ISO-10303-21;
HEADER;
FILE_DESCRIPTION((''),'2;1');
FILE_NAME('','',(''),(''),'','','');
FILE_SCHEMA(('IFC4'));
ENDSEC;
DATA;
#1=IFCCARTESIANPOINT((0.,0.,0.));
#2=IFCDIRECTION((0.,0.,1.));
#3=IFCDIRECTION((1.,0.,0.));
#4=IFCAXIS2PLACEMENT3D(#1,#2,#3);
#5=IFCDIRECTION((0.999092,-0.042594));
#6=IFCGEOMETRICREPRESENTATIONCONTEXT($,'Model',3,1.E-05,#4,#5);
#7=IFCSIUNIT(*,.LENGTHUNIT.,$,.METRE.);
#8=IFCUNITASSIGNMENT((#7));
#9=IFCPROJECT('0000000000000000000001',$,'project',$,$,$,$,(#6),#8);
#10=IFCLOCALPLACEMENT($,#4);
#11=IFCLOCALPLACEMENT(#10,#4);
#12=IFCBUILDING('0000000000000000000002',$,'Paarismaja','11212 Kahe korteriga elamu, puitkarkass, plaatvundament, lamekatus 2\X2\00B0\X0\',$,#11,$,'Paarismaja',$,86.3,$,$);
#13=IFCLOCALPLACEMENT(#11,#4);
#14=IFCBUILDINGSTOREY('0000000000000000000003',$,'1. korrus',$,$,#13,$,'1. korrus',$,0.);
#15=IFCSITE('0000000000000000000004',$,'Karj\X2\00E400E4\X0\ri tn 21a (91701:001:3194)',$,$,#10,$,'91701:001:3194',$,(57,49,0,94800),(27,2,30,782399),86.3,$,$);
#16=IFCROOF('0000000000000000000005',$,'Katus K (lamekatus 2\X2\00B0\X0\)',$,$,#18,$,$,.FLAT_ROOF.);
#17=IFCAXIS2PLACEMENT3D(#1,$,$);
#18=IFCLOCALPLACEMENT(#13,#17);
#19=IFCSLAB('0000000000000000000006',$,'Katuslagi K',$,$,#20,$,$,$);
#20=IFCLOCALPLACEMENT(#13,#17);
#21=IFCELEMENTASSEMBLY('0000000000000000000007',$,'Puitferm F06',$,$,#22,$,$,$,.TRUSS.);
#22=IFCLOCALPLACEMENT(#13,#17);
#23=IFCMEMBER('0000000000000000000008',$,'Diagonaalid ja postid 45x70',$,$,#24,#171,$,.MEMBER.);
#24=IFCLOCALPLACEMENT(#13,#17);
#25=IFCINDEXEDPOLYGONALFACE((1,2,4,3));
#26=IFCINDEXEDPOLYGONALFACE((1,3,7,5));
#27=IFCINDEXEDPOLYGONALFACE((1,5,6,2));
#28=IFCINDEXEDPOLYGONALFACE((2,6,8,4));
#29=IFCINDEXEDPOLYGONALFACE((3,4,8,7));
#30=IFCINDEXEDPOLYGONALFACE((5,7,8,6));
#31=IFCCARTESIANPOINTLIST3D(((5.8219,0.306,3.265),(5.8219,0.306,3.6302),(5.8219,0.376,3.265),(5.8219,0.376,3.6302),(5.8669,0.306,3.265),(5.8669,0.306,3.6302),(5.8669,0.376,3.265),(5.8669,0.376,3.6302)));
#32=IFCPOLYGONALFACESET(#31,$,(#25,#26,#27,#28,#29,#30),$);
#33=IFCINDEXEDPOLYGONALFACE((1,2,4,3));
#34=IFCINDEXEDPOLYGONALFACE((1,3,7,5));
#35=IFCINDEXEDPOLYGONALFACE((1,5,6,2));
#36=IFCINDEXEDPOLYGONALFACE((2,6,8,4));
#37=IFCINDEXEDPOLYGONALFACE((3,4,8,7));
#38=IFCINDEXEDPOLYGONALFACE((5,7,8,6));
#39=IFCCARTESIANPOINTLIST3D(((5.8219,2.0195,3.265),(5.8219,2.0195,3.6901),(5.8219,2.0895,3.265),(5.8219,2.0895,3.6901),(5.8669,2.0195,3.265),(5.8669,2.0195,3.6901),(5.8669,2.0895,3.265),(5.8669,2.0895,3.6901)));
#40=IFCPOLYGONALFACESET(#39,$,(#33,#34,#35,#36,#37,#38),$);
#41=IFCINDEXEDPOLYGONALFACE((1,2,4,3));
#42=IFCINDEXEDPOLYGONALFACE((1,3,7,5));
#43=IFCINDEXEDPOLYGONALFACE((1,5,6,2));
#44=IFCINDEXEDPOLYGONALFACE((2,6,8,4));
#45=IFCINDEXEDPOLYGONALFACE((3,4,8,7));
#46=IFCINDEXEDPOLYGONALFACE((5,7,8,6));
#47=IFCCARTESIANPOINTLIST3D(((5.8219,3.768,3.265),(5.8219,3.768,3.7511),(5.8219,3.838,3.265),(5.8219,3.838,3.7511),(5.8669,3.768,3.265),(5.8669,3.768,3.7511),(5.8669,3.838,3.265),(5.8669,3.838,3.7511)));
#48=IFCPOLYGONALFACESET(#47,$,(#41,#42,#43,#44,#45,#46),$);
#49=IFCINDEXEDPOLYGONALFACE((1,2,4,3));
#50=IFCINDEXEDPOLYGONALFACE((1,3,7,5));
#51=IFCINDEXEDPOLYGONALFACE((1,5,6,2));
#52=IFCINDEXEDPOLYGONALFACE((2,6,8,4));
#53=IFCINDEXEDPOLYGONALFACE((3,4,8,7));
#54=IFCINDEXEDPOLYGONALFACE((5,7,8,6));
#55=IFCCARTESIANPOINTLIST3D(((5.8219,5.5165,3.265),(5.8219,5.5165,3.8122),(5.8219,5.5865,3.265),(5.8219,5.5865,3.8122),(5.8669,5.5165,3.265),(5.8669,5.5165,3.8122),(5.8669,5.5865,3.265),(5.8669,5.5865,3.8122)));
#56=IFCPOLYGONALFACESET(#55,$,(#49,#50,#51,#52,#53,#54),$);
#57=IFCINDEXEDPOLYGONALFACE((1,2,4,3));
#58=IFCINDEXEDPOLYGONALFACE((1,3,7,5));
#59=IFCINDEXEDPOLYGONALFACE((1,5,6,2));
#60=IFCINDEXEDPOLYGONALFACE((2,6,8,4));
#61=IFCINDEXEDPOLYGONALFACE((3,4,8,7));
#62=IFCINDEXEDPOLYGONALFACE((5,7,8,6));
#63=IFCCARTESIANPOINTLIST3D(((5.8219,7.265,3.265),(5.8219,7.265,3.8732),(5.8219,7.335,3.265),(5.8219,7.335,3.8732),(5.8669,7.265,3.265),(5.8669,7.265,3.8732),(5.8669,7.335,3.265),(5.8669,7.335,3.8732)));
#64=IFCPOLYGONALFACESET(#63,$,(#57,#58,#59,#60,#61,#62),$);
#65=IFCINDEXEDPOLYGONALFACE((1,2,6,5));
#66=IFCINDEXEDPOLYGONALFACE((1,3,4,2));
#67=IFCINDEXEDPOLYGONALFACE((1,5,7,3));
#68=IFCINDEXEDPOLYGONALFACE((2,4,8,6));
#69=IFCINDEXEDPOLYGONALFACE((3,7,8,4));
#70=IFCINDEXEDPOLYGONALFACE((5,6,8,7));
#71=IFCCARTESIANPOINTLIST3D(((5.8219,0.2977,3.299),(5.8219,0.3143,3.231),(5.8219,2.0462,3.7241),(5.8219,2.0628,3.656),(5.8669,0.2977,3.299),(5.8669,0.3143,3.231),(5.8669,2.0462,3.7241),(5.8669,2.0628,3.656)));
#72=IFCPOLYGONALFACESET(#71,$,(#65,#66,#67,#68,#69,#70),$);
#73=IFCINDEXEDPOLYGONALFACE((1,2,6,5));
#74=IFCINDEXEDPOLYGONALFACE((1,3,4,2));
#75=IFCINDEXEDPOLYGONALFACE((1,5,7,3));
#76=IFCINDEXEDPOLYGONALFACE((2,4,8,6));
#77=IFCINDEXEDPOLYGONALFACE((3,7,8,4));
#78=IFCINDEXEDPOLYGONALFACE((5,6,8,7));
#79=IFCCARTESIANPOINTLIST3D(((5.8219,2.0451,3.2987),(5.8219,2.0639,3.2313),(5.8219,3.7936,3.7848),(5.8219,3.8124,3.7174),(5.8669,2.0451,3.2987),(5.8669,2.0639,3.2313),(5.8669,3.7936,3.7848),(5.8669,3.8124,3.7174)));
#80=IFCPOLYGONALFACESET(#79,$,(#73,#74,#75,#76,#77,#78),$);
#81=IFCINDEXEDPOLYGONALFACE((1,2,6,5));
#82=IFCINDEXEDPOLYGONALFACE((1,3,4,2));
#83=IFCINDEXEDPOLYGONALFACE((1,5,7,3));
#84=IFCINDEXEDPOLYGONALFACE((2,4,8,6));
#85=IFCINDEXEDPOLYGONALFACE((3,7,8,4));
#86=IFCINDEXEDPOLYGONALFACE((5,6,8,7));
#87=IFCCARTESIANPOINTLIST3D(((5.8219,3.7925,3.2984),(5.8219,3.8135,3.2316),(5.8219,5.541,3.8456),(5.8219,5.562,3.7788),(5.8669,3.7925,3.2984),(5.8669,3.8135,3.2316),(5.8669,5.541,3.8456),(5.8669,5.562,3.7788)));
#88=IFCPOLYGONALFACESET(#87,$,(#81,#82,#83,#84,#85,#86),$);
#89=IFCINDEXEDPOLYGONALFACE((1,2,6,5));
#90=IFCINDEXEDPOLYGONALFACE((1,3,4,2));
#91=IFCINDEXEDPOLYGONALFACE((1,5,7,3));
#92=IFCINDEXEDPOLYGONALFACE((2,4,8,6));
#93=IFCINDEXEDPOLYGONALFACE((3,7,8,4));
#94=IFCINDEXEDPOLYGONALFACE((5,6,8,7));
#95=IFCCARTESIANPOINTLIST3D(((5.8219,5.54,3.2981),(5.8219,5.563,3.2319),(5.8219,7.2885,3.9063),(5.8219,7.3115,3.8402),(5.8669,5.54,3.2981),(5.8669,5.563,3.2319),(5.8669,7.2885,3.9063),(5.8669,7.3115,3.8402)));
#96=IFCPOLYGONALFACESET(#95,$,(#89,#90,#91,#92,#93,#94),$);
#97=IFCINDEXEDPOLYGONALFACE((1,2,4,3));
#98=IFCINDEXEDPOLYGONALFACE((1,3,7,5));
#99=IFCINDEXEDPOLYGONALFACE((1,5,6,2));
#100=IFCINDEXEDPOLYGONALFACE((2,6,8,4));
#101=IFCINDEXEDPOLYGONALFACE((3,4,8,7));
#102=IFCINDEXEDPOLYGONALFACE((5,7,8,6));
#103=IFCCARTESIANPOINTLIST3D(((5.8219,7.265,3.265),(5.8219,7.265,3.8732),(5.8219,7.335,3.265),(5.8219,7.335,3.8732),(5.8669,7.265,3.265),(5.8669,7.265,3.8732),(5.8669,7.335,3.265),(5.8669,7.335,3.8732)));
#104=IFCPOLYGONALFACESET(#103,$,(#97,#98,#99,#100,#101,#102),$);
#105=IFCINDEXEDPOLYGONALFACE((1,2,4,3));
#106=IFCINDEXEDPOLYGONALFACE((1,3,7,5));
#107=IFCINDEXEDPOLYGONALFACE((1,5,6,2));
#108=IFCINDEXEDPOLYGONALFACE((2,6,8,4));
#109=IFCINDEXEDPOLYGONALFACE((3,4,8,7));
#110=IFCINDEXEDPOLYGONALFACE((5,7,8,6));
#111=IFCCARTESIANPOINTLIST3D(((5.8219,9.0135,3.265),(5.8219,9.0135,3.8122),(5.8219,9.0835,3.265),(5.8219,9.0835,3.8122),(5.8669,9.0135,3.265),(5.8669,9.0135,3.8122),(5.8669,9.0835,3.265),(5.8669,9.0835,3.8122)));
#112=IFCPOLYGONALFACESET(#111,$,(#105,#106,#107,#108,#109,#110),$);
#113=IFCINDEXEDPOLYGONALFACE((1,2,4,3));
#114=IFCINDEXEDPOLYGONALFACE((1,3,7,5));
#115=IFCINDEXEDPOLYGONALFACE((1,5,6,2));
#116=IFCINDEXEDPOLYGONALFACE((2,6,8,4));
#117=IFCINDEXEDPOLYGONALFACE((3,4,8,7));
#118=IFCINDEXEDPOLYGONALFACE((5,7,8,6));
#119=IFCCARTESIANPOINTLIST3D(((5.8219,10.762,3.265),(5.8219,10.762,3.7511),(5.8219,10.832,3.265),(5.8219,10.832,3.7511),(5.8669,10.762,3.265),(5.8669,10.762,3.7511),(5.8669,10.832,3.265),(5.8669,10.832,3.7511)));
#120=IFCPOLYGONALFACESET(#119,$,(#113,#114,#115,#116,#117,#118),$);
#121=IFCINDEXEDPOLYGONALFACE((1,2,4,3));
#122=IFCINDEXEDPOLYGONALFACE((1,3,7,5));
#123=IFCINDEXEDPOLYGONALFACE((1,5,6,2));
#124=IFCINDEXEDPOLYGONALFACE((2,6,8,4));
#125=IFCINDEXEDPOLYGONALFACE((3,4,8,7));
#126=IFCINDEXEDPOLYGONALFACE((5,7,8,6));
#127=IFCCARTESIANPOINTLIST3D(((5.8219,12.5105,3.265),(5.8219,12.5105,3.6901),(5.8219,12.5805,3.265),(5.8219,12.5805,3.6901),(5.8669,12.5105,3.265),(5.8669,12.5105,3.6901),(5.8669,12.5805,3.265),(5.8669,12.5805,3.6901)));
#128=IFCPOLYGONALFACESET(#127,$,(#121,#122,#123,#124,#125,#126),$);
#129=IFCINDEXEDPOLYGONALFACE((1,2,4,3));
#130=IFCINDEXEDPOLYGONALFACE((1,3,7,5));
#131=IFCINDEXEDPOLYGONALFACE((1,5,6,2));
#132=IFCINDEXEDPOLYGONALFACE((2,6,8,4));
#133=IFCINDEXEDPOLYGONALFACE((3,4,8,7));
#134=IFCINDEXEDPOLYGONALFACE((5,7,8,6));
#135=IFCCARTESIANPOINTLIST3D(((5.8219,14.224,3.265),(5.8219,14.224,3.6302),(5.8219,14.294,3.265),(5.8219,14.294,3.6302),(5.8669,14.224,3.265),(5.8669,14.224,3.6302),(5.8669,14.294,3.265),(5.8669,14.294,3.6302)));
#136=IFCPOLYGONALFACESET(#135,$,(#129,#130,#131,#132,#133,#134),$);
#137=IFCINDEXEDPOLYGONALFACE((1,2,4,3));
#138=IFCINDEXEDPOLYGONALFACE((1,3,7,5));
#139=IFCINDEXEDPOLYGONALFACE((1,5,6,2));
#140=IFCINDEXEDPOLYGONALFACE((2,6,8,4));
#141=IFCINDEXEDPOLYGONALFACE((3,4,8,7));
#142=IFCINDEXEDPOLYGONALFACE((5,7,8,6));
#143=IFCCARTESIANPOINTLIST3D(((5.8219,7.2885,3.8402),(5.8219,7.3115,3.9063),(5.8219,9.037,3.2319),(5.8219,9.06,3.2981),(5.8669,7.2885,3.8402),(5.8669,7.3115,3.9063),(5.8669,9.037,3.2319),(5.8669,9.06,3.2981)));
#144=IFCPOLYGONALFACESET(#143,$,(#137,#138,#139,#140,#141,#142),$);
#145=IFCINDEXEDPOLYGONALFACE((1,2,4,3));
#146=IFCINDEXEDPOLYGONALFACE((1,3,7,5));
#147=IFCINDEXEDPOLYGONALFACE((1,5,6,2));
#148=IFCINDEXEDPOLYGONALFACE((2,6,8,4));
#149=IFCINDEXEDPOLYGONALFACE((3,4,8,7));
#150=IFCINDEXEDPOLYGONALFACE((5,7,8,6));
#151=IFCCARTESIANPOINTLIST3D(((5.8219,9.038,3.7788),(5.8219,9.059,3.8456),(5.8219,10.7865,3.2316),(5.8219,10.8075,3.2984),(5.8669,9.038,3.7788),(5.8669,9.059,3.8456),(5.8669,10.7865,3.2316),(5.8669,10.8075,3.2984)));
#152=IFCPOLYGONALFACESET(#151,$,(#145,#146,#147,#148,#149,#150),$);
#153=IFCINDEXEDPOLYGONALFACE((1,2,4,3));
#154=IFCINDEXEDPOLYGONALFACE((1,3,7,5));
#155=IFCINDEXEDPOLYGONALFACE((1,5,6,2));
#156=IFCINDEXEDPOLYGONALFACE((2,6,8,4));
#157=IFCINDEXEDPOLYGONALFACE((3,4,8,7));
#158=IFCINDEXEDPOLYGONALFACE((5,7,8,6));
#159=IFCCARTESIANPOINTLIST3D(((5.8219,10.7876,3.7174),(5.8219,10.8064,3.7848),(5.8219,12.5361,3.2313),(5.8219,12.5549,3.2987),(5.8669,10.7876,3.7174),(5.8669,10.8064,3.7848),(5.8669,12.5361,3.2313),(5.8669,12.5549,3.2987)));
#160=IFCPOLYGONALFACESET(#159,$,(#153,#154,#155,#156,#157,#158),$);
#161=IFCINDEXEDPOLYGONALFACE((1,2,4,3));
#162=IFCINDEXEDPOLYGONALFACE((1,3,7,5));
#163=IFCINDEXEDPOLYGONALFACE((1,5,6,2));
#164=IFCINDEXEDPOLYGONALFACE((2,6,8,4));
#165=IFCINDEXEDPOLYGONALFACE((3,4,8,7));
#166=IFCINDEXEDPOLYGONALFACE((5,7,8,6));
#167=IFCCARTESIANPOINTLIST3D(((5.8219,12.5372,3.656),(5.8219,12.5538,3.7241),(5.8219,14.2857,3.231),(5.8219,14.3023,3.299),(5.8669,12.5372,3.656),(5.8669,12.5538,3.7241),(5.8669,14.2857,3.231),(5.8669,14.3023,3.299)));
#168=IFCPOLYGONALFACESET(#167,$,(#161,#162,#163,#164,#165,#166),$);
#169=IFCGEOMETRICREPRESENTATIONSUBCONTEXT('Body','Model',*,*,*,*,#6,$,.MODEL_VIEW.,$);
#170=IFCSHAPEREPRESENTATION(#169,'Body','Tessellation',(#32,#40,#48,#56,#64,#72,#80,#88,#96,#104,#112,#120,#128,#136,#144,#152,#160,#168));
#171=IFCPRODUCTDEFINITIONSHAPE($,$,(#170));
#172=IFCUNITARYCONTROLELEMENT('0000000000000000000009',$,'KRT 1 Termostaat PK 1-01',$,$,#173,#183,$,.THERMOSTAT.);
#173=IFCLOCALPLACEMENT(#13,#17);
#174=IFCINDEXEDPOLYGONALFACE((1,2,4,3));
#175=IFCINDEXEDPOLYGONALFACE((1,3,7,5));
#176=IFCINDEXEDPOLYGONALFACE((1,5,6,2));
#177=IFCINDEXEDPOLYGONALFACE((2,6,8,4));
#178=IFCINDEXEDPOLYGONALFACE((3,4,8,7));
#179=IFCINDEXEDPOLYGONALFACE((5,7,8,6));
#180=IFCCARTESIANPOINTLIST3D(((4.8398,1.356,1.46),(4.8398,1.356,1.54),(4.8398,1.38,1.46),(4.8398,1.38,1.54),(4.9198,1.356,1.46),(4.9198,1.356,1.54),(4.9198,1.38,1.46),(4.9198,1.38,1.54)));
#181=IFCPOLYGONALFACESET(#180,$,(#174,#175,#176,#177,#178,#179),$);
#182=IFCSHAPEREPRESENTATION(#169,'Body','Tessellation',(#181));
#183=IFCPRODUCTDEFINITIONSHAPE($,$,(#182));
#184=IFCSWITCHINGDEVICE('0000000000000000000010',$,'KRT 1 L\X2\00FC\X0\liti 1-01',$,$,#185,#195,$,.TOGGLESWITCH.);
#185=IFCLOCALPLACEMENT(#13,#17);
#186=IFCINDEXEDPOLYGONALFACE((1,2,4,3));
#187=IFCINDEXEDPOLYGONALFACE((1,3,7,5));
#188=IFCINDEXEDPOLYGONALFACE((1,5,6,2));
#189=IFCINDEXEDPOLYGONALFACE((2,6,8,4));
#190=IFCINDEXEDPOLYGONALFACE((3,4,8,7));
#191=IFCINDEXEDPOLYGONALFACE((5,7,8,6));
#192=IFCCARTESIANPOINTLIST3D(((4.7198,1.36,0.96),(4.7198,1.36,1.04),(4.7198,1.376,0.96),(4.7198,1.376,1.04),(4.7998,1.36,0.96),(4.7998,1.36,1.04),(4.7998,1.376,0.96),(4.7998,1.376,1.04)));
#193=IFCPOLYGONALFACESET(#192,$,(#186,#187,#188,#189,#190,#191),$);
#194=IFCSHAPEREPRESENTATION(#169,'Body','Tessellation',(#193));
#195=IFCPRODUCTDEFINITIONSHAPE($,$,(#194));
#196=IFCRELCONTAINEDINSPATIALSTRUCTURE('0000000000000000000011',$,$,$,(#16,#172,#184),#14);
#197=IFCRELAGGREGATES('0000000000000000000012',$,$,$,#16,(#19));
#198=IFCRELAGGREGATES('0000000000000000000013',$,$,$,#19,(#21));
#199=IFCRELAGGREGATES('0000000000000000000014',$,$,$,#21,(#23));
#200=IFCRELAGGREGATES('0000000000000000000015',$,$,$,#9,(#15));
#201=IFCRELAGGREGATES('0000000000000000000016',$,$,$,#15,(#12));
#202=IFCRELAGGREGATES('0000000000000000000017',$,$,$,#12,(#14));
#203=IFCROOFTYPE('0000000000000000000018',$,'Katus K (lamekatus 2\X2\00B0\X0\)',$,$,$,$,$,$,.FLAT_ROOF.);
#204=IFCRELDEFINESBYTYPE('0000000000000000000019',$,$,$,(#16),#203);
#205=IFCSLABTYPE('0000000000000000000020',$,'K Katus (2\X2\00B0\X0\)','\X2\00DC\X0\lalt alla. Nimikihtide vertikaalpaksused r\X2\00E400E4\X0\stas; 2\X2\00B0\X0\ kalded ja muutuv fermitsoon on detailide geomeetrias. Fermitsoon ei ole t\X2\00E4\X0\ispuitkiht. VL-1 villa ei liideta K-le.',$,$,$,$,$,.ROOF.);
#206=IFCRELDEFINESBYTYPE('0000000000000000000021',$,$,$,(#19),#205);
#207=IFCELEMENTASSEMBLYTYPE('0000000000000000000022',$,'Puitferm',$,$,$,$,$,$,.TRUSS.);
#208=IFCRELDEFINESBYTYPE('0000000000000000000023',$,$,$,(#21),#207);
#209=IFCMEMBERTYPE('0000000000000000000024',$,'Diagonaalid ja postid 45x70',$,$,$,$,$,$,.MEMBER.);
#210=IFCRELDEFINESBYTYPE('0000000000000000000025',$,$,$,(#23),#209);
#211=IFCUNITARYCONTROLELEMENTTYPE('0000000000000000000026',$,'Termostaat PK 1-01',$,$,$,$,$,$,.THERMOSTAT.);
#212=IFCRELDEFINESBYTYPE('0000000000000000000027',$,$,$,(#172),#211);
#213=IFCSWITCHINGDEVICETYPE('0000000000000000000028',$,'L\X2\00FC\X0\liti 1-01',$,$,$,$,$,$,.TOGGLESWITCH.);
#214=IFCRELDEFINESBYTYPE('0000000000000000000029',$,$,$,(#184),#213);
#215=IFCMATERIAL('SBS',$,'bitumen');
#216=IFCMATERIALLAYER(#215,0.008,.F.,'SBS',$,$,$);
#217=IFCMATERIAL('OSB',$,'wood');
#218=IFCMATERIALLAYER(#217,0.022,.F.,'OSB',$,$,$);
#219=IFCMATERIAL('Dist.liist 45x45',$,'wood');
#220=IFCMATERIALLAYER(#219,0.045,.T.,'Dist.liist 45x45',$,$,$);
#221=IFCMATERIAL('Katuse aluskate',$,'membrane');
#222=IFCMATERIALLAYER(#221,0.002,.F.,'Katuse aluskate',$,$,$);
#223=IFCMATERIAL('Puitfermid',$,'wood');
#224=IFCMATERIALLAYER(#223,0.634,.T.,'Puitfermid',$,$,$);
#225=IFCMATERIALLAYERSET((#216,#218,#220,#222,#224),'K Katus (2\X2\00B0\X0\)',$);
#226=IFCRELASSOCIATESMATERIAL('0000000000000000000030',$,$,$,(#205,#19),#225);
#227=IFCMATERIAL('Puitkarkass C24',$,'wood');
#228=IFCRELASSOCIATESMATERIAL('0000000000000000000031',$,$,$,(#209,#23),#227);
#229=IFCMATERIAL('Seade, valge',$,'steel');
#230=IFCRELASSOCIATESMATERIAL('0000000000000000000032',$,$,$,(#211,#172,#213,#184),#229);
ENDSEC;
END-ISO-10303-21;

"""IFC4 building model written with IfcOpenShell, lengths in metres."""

from ifc_helpers import new_model, si_unit, direction, frame, origin_with_axes, place, context, subcontext, project, spatial, indexed_curve, outline, extrude, material, layer, layer_set, layer_usage, type_object, element, aggregate, save


model = new_model("IFC4")

# Units and contexts
model_context = context("Model", 3, precision=1e-05, world=origin_with_axes(), true_north=direction((0.999092, -0.042594)))
body_context = subcontext(model_context, "Body", "Model", "MODEL_VIEW")
ifc_project = project(units=[si_unit("LENGTHUNIT", "METRE")], contexts=[model_context])

# Site, building, storey
site_placement = place(None, origin_with_axes())
site = spatial("IfcSite", under=ifc_project, at=site_placement, Name="Karjääri tn 21a (91701:001:3194)", LongName="91701:001:3194", RefLatitude=(57, 49, 0, 94800), RefLongitude=(27, 2, 30, 782399), RefElevation=86.3)
building_placement = place(site_placement, origin_with_axes())
building = spatial("IfcBuilding", under=site, at=building_placement, Name="Paarismaja", Description="11212 Kahe korteriga elamu, puitkarkass, plaatvundament, lamekatus 2°", LongName="Paarismaja", ElevationOfRefHeight=86.3)
storey_placement = place(building_placement, origin_with_axes())
storey = spatial("IfcBuildingStorey", under=building, at=storey_placement, Name="1. korrus", LongName="1. korrus", Elevation=0.0)

# Shared definitions
ifc_material_1 = material(Name="Puitkarkass C24", Category="wood")

# Roof, slab, element assembly, member
roof_type = type_object("IfcRoofType", Name="Katus K (lamekatus 2°)", PredefinedType="FLAT_ROOF")
roof_placement = place(storey_placement, origin_with_axes())
roof = element("IfcRoof", 1, at=roof_placement, inside=storey, type_object=roof_type, Name="Katus K (lamekatus 2°)", PredefinedType="FLAT_ROOF")
ifc_material_2 = material(Name="SBS", Category="bitumen")
ifc_layer_1 = layer(ifc_material_2, 0.008, ventilated=False, Name="SBS")
ifc_material_3 = material(Name="OSB", Category="wood")
ifc_layer_2 = layer(ifc_material_3, 0.022, ventilated=False, Name="OSB")
ifc_material_4 = material(Name="Dist.liist 45x45", Category="wood")
ifc_layer_3 = layer(ifc_material_4, 0.045, ventilated=True, Name="Dist.liist 45x45")
ifc_material_5 = material(Name="Katuse aluskate", Category="membrane")
ifc_layer_4 = layer(ifc_material_5, 0.002, ventilated=False, Name="Katuse aluskate")
ifc_material_6 = material(Name="Puitfermid", Category="wood")
ifc_layer_5 = layer(ifc_material_6, 0.634, ventilated=True, Name="Puitfermid")
ifc_layer_set_1 = layer_set([ifc_layer_1, ifc_layer_2, ifc_layer_3, ifc_layer_4, ifc_layer_5], Name="K Katus (2°)")
ifc_layer_usage_1 = layer_usage(ifc_layer_set_1, "AXIS3", "NEGATIVE", 3.801)
slab_type = type_object("IfcSlabType", Name="K Katus (2°)", Description="Ülalt alla. Nimikihtide vertikaalpaksused räästas; 2° kalded ja muutuv fermitsoon on detailide geomeetrias. Fermitsoon ei ole täispuitkiht. VL-1 villa ei liideta K-le.", PredefinedType="ROOF", material=ifc_layer_set_1)
slab_placement = place(roof_placement, origin_with_axes())
slab = element("IfcSlab", 2, at=slab_placement, type_object=slab_type, material=ifc_layer_usage_1, Name="Katuslagi K")
aggregate(roof, [slab])
element_assembly_type = type_object("IfcElementAssemblyType", Name="Puitferm", PredefinedType="TRUSS")
assembly_1_placement = place(slab_placement, frame((5.8219, 0.0, 0.0), z_axis=(0.0, 0.0, 1.0), x_axis=(1.0, 0.0, 0.0)))
assembly_1 = element("IfcElementAssembly", 3, at=assembly_1_placement, type_object=element_assembly_type, Name="Puitferm F06", PredefinedType="TRUSS")
aggregate(slab, [assembly_1])
member_type_1 = type_object("IfcMemberType", Name="Diagonaalid ja postid 45x70", PredefinedType="MEMBER", material=ifc_material_1)
member_1_placement = place(assembly_1_placement, origin_with_axes())
member_1 = element("IfcMember", 4, at=member_1_placement, type_object=member_type_1, material=ifc_material_1, Name="Diagonaalid ja postid 45x70", PredefinedType="MEMBER", context=body_context, shape_type="SweptSolid", body=[
    extrude(outline(indexed_curve([(0.306, 3.265), (0.306, 3.6302), (0.376, 3.6302), (0.376, 3.265), (0.306, 3.265)], self_intersect=False)), frame((0.0, 0.0, 0.0), z_axis=(1.0, 0.0, 0.0), x_axis=(0.0, 1.0, 0.0)), (0.0, 0.0, 1.0), 0.045),
    extrude(outline(indexed_curve([(2.0195, 3.265), (2.0195, 3.6901), (2.0895, 3.6901), (2.0895, 3.265), (2.0195, 3.265)], self_intersect=False)), frame((0.0, 0.0, 0.0), z_axis=(1.0, 0.0, 0.0), x_axis=(0.0, 1.0, 0.0)), (0.0, 0.0, 1.0), 0.045),
    extrude(outline(indexed_curve([(3.768, 3.265), (3.768, 3.7511), (3.838, 3.7511), (3.838, 3.265), (3.768, 3.265)], self_intersect=False)), frame((0.0, 0.0, 0.0), z_axis=(1.0, 0.0, 0.0), x_axis=(0.0, 1.0, 0.0)), (0.0, 0.0, 1.0), 0.045),
    extrude(outline(indexed_curve([(5.5165, 3.265), (5.5165, 3.8122), (5.5865, 3.8122), (5.5865, 3.265), (5.5165, 3.265)], self_intersect=False)), frame((0.0, 0.0, 0.0), z_axis=(1.0, 0.0, 0.0), x_axis=(0.0, 1.0, 0.0)), (0.0, 0.0, 1.0), 0.045),
    extrude(outline(indexed_curve([(7.265, 3.265), (7.265, 3.8732), (7.335, 3.8732), (7.335, 3.265), (7.265, 3.265)], self_intersect=False)), frame((0.0, 0.0, 0.0), z_axis=(1.0, 0.0, 0.0), x_axis=(0.0, 1.0, 0.0)), (0.0, 0.0, 1.0), 0.045),
    extrude(outline(indexed_curve([(0.2977, 3.299), (2.0462, 3.7241), (2.0628, 3.656), (0.3143, 3.231), (0.2977, 3.299)], self_intersect=False)), frame((0.0, 0.0, 0.0), z_axis=(1.0, 0.0, 0.0), x_axis=(0.0, 1.0, 0.0)), (0.0, 0.0, 1.0), 0.045),
    extrude(outline(indexed_curve([(2.0451, 3.2987), (3.7936, 3.7848), (3.8124, 3.7174), (2.0639, 3.2313), (2.0451, 3.2987)], self_intersect=False)), frame((0.0, 0.0, 0.0), z_axis=(1.0, 0.0, 0.0), x_axis=(0.0, 1.0, 0.0)), (0.0, 0.0, 1.0), 0.045),
    extrude(outline(indexed_curve([(3.7925, 3.2984), (5.541, 3.8456), (5.562, 3.7788), (3.8135, 3.2316), (3.7925, 3.2984)], self_intersect=False)), frame((0.0, 0.0, 0.0), z_axis=(1.0, 0.0, 0.0), x_axis=(0.0, 1.0, 0.0)), (0.0, 0.0, 1.0), 0.045),
    extrude(outline(indexed_curve([(5.54, 3.2981), (7.2885, 3.9063), (7.3115, 3.8402), (5.563, 3.2319), (5.54, 3.2981)], self_intersect=False)), frame((0.0, 0.0, 0.0), z_axis=(1.0, 0.0, 0.0), x_axis=(0.0, 1.0, 0.0)), (0.0, 0.0, 1.0), 0.045),
    extrude(outline(indexed_curve([(7.265, 3.265), (7.265, 3.8732), (7.335, 3.8732), (7.335, 3.265), (7.265, 3.265)], self_intersect=False)), frame((0.0, 0.0, 0.0), z_axis=(1.0, 0.0, 0.0), x_axis=(0.0, 1.0, 0.0)), (0.0, 0.0, 1.0), 0.045),
    extrude(outline(indexed_curve([(9.0135, 3.265), (9.0135, 3.8122), (9.0835, 3.8122), (9.0835, 3.265), (9.0135, 3.265)], self_intersect=False)), frame((0.0, 0.0, 0.0), z_axis=(1.0, 0.0, 0.0), x_axis=(0.0, 1.0, 0.0)), (0.0, 0.0, 1.0), 0.045),
    extrude(outline(indexed_curve([(10.762, 3.265), (10.762, 3.7511), (10.832, 3.7511), (10.832, 3.265), (10.762, 3.265)], self_intersect=False)), frame((0.0, 0.0, 0.0), z_axis=(1.0, 0.0, 0.0), x_axis=(0.0, 1.0, 0.0)), (0.0, 0.0, 1.0), 0.045),
    extrude(outline(indexed_curve([(12.5105, 3.265), (12.5105, 3.6901), (12.5805, 3.6901), (12.5805, 3.265), (12.5105, 3.265)], self_intersect=False)), frame((0.0, 0.0, 0.0), z_axis=(1.0, 0.0, 0.0), x_axis=(0.0, 1.0, 0.0)), (0.0, 0.0, 1.0), 0.045),
    extrude(outline(indexed_curve([(14.224, 3.265), (14.224, 3.6302), (14.294, 3.6302), (14.294, 3.265), (14.224, 3.265)], self_intersect=False)), frame((0.0, 0.0, 0.0), z_axis=(1.0, 0.0, 0.0), x_axis=(0.0, 1.0, 0.0)), (0.0, 0.0, 1.0), 0.045),
    extrude(outline(indexed_curve([(9.037, 3.2319), (7.2885, 3.8402), (7.3115, 3.9063), (9.06, 3.2981), (9.037, 3.2319)], self_intersect=False)), frame((0.0, 0.0, 0.0), z_axis=(1.0, 0.0, 0.0), x_axis=(0.0, 1.0, 0.0)), (0.0, 0.0, 1.0), 0.045),
    extrude(outline(indexed_curve([(10.7865, 3.2316), (9.038, 3.7788), (9.059, 3.8456), (10.8075, 3.2984), (10.7865, 3.2316)], self_intersect=False)), frame((0.0, 0.0, 0.0), z_axis=(1.0, 0.0, 0.0), x_axis=(0.0, 1.0, 0.0)), (0.0, 0.0, 1.0), 0.045),
    extrude(outline(indexed_curve([(12.5361, 3.2313), (10.7876, 3.7174), (10.8064, 3.7848), (12.5549, 3.2987), (12.5361, 3.2313)], self_intersect=False)), frame((0.0, 0.0, 0.0), z_axis=(1.0, 0.0, 0.0), x_axis=(0.0, 1.0, 0.0)), (0.0, 0.0, 1.0), 0.045),
    extrude(outline(indexed_curve([(14.2857, 3.231), (12.5372, 3.656), (12.5538, 3.7241), (14.3023, 3.299), (14.2857, 3.231)], self_intersect=False)), frame((0.0, 0.0, 0.0), z_axis=(1.0, 0.0, 0.0), x_axis=(0.0, 1.0, 0.0)), (0.0, 0.0, 1.0), 0.045),
])
aggregate(assembly_1, [member_1])

# Unitary control element
ifc_material_7 = material(Name="Seade, valge", Category="steel")
unitary_control_element_type = type_object("IfcUnitaryControlElementType", Name="Termostaat PK 1-01", PredefinedType="THERMOSTAT", material=ifc_material_7)
unitary_control_element_placement = place(storey_placement, frame((4.8798, 1.368, 0.0), z_axis=(0.0, 0.0, 1.0), x_axis=(1.0, 0.0, 0.0)))
element("IfcUnitaryControlElement", 5, at=unitary_control_element_placement, inside=storey, type_object=unitary_control_element_type, material=ifc_material_7, Name="KRT 1 Termostaat PK 1-01", PredefinedType="THERMOSTAT", context=body_context, shape_type="SweptSolid", body=[
    extrude(outline(indexed_curve([(-0.04, -0.012), (0.04, -0.012), (0.04, 0.012), (-0.04, 0.012), (-0.04, -0.012)], self_intersect=False)), frame((0.0, 0.0, 1.46), z_axis=(0.0, 0.0, 1.0), x_axis=(1.0, 0.0, 0.0)), (0.0, 0.0, 1.0), 0.08),
])

# Switching device
switching_device_type = type_object("IfcSwitchingDeviceType", Name="Lüliti 1-01", PredefinedType="TOGGLESWITCH", material=ifc_material_7)
switching_device_placement = place(storey_placement, frame((4.7598, 1.368, 0.0), z_axis=(0.0, 0.0, 1.0), x_axis=(1.0, 0.0, 0.0)))
element("IfcSwitchingDevice", 6, at=switching_device_placement, inside=storey, type_object=switching_device_type, material=ifc_material_7, Name="KRT 1 Lüliti 1-01", PredefinedType="TOGGLESWITCH", context=body_context, shape_type="SweptSolid", body=[
    extrude(outline(indexed_curve([(-0.04, -0.008), (0.04, -0.008), (0.04, 0.008), (-0.04, 0.008), (-0.04, -0.008)], self_intersect=False)), frame((0.0, 0.0, 0.96), z_axis=(0.0, 0.0, 1.0), x_axis=(1.0, 0.0, 0.0)), (0.0, 0.0, 1.0), 0.08),
])

save(model, "model.ifc")
